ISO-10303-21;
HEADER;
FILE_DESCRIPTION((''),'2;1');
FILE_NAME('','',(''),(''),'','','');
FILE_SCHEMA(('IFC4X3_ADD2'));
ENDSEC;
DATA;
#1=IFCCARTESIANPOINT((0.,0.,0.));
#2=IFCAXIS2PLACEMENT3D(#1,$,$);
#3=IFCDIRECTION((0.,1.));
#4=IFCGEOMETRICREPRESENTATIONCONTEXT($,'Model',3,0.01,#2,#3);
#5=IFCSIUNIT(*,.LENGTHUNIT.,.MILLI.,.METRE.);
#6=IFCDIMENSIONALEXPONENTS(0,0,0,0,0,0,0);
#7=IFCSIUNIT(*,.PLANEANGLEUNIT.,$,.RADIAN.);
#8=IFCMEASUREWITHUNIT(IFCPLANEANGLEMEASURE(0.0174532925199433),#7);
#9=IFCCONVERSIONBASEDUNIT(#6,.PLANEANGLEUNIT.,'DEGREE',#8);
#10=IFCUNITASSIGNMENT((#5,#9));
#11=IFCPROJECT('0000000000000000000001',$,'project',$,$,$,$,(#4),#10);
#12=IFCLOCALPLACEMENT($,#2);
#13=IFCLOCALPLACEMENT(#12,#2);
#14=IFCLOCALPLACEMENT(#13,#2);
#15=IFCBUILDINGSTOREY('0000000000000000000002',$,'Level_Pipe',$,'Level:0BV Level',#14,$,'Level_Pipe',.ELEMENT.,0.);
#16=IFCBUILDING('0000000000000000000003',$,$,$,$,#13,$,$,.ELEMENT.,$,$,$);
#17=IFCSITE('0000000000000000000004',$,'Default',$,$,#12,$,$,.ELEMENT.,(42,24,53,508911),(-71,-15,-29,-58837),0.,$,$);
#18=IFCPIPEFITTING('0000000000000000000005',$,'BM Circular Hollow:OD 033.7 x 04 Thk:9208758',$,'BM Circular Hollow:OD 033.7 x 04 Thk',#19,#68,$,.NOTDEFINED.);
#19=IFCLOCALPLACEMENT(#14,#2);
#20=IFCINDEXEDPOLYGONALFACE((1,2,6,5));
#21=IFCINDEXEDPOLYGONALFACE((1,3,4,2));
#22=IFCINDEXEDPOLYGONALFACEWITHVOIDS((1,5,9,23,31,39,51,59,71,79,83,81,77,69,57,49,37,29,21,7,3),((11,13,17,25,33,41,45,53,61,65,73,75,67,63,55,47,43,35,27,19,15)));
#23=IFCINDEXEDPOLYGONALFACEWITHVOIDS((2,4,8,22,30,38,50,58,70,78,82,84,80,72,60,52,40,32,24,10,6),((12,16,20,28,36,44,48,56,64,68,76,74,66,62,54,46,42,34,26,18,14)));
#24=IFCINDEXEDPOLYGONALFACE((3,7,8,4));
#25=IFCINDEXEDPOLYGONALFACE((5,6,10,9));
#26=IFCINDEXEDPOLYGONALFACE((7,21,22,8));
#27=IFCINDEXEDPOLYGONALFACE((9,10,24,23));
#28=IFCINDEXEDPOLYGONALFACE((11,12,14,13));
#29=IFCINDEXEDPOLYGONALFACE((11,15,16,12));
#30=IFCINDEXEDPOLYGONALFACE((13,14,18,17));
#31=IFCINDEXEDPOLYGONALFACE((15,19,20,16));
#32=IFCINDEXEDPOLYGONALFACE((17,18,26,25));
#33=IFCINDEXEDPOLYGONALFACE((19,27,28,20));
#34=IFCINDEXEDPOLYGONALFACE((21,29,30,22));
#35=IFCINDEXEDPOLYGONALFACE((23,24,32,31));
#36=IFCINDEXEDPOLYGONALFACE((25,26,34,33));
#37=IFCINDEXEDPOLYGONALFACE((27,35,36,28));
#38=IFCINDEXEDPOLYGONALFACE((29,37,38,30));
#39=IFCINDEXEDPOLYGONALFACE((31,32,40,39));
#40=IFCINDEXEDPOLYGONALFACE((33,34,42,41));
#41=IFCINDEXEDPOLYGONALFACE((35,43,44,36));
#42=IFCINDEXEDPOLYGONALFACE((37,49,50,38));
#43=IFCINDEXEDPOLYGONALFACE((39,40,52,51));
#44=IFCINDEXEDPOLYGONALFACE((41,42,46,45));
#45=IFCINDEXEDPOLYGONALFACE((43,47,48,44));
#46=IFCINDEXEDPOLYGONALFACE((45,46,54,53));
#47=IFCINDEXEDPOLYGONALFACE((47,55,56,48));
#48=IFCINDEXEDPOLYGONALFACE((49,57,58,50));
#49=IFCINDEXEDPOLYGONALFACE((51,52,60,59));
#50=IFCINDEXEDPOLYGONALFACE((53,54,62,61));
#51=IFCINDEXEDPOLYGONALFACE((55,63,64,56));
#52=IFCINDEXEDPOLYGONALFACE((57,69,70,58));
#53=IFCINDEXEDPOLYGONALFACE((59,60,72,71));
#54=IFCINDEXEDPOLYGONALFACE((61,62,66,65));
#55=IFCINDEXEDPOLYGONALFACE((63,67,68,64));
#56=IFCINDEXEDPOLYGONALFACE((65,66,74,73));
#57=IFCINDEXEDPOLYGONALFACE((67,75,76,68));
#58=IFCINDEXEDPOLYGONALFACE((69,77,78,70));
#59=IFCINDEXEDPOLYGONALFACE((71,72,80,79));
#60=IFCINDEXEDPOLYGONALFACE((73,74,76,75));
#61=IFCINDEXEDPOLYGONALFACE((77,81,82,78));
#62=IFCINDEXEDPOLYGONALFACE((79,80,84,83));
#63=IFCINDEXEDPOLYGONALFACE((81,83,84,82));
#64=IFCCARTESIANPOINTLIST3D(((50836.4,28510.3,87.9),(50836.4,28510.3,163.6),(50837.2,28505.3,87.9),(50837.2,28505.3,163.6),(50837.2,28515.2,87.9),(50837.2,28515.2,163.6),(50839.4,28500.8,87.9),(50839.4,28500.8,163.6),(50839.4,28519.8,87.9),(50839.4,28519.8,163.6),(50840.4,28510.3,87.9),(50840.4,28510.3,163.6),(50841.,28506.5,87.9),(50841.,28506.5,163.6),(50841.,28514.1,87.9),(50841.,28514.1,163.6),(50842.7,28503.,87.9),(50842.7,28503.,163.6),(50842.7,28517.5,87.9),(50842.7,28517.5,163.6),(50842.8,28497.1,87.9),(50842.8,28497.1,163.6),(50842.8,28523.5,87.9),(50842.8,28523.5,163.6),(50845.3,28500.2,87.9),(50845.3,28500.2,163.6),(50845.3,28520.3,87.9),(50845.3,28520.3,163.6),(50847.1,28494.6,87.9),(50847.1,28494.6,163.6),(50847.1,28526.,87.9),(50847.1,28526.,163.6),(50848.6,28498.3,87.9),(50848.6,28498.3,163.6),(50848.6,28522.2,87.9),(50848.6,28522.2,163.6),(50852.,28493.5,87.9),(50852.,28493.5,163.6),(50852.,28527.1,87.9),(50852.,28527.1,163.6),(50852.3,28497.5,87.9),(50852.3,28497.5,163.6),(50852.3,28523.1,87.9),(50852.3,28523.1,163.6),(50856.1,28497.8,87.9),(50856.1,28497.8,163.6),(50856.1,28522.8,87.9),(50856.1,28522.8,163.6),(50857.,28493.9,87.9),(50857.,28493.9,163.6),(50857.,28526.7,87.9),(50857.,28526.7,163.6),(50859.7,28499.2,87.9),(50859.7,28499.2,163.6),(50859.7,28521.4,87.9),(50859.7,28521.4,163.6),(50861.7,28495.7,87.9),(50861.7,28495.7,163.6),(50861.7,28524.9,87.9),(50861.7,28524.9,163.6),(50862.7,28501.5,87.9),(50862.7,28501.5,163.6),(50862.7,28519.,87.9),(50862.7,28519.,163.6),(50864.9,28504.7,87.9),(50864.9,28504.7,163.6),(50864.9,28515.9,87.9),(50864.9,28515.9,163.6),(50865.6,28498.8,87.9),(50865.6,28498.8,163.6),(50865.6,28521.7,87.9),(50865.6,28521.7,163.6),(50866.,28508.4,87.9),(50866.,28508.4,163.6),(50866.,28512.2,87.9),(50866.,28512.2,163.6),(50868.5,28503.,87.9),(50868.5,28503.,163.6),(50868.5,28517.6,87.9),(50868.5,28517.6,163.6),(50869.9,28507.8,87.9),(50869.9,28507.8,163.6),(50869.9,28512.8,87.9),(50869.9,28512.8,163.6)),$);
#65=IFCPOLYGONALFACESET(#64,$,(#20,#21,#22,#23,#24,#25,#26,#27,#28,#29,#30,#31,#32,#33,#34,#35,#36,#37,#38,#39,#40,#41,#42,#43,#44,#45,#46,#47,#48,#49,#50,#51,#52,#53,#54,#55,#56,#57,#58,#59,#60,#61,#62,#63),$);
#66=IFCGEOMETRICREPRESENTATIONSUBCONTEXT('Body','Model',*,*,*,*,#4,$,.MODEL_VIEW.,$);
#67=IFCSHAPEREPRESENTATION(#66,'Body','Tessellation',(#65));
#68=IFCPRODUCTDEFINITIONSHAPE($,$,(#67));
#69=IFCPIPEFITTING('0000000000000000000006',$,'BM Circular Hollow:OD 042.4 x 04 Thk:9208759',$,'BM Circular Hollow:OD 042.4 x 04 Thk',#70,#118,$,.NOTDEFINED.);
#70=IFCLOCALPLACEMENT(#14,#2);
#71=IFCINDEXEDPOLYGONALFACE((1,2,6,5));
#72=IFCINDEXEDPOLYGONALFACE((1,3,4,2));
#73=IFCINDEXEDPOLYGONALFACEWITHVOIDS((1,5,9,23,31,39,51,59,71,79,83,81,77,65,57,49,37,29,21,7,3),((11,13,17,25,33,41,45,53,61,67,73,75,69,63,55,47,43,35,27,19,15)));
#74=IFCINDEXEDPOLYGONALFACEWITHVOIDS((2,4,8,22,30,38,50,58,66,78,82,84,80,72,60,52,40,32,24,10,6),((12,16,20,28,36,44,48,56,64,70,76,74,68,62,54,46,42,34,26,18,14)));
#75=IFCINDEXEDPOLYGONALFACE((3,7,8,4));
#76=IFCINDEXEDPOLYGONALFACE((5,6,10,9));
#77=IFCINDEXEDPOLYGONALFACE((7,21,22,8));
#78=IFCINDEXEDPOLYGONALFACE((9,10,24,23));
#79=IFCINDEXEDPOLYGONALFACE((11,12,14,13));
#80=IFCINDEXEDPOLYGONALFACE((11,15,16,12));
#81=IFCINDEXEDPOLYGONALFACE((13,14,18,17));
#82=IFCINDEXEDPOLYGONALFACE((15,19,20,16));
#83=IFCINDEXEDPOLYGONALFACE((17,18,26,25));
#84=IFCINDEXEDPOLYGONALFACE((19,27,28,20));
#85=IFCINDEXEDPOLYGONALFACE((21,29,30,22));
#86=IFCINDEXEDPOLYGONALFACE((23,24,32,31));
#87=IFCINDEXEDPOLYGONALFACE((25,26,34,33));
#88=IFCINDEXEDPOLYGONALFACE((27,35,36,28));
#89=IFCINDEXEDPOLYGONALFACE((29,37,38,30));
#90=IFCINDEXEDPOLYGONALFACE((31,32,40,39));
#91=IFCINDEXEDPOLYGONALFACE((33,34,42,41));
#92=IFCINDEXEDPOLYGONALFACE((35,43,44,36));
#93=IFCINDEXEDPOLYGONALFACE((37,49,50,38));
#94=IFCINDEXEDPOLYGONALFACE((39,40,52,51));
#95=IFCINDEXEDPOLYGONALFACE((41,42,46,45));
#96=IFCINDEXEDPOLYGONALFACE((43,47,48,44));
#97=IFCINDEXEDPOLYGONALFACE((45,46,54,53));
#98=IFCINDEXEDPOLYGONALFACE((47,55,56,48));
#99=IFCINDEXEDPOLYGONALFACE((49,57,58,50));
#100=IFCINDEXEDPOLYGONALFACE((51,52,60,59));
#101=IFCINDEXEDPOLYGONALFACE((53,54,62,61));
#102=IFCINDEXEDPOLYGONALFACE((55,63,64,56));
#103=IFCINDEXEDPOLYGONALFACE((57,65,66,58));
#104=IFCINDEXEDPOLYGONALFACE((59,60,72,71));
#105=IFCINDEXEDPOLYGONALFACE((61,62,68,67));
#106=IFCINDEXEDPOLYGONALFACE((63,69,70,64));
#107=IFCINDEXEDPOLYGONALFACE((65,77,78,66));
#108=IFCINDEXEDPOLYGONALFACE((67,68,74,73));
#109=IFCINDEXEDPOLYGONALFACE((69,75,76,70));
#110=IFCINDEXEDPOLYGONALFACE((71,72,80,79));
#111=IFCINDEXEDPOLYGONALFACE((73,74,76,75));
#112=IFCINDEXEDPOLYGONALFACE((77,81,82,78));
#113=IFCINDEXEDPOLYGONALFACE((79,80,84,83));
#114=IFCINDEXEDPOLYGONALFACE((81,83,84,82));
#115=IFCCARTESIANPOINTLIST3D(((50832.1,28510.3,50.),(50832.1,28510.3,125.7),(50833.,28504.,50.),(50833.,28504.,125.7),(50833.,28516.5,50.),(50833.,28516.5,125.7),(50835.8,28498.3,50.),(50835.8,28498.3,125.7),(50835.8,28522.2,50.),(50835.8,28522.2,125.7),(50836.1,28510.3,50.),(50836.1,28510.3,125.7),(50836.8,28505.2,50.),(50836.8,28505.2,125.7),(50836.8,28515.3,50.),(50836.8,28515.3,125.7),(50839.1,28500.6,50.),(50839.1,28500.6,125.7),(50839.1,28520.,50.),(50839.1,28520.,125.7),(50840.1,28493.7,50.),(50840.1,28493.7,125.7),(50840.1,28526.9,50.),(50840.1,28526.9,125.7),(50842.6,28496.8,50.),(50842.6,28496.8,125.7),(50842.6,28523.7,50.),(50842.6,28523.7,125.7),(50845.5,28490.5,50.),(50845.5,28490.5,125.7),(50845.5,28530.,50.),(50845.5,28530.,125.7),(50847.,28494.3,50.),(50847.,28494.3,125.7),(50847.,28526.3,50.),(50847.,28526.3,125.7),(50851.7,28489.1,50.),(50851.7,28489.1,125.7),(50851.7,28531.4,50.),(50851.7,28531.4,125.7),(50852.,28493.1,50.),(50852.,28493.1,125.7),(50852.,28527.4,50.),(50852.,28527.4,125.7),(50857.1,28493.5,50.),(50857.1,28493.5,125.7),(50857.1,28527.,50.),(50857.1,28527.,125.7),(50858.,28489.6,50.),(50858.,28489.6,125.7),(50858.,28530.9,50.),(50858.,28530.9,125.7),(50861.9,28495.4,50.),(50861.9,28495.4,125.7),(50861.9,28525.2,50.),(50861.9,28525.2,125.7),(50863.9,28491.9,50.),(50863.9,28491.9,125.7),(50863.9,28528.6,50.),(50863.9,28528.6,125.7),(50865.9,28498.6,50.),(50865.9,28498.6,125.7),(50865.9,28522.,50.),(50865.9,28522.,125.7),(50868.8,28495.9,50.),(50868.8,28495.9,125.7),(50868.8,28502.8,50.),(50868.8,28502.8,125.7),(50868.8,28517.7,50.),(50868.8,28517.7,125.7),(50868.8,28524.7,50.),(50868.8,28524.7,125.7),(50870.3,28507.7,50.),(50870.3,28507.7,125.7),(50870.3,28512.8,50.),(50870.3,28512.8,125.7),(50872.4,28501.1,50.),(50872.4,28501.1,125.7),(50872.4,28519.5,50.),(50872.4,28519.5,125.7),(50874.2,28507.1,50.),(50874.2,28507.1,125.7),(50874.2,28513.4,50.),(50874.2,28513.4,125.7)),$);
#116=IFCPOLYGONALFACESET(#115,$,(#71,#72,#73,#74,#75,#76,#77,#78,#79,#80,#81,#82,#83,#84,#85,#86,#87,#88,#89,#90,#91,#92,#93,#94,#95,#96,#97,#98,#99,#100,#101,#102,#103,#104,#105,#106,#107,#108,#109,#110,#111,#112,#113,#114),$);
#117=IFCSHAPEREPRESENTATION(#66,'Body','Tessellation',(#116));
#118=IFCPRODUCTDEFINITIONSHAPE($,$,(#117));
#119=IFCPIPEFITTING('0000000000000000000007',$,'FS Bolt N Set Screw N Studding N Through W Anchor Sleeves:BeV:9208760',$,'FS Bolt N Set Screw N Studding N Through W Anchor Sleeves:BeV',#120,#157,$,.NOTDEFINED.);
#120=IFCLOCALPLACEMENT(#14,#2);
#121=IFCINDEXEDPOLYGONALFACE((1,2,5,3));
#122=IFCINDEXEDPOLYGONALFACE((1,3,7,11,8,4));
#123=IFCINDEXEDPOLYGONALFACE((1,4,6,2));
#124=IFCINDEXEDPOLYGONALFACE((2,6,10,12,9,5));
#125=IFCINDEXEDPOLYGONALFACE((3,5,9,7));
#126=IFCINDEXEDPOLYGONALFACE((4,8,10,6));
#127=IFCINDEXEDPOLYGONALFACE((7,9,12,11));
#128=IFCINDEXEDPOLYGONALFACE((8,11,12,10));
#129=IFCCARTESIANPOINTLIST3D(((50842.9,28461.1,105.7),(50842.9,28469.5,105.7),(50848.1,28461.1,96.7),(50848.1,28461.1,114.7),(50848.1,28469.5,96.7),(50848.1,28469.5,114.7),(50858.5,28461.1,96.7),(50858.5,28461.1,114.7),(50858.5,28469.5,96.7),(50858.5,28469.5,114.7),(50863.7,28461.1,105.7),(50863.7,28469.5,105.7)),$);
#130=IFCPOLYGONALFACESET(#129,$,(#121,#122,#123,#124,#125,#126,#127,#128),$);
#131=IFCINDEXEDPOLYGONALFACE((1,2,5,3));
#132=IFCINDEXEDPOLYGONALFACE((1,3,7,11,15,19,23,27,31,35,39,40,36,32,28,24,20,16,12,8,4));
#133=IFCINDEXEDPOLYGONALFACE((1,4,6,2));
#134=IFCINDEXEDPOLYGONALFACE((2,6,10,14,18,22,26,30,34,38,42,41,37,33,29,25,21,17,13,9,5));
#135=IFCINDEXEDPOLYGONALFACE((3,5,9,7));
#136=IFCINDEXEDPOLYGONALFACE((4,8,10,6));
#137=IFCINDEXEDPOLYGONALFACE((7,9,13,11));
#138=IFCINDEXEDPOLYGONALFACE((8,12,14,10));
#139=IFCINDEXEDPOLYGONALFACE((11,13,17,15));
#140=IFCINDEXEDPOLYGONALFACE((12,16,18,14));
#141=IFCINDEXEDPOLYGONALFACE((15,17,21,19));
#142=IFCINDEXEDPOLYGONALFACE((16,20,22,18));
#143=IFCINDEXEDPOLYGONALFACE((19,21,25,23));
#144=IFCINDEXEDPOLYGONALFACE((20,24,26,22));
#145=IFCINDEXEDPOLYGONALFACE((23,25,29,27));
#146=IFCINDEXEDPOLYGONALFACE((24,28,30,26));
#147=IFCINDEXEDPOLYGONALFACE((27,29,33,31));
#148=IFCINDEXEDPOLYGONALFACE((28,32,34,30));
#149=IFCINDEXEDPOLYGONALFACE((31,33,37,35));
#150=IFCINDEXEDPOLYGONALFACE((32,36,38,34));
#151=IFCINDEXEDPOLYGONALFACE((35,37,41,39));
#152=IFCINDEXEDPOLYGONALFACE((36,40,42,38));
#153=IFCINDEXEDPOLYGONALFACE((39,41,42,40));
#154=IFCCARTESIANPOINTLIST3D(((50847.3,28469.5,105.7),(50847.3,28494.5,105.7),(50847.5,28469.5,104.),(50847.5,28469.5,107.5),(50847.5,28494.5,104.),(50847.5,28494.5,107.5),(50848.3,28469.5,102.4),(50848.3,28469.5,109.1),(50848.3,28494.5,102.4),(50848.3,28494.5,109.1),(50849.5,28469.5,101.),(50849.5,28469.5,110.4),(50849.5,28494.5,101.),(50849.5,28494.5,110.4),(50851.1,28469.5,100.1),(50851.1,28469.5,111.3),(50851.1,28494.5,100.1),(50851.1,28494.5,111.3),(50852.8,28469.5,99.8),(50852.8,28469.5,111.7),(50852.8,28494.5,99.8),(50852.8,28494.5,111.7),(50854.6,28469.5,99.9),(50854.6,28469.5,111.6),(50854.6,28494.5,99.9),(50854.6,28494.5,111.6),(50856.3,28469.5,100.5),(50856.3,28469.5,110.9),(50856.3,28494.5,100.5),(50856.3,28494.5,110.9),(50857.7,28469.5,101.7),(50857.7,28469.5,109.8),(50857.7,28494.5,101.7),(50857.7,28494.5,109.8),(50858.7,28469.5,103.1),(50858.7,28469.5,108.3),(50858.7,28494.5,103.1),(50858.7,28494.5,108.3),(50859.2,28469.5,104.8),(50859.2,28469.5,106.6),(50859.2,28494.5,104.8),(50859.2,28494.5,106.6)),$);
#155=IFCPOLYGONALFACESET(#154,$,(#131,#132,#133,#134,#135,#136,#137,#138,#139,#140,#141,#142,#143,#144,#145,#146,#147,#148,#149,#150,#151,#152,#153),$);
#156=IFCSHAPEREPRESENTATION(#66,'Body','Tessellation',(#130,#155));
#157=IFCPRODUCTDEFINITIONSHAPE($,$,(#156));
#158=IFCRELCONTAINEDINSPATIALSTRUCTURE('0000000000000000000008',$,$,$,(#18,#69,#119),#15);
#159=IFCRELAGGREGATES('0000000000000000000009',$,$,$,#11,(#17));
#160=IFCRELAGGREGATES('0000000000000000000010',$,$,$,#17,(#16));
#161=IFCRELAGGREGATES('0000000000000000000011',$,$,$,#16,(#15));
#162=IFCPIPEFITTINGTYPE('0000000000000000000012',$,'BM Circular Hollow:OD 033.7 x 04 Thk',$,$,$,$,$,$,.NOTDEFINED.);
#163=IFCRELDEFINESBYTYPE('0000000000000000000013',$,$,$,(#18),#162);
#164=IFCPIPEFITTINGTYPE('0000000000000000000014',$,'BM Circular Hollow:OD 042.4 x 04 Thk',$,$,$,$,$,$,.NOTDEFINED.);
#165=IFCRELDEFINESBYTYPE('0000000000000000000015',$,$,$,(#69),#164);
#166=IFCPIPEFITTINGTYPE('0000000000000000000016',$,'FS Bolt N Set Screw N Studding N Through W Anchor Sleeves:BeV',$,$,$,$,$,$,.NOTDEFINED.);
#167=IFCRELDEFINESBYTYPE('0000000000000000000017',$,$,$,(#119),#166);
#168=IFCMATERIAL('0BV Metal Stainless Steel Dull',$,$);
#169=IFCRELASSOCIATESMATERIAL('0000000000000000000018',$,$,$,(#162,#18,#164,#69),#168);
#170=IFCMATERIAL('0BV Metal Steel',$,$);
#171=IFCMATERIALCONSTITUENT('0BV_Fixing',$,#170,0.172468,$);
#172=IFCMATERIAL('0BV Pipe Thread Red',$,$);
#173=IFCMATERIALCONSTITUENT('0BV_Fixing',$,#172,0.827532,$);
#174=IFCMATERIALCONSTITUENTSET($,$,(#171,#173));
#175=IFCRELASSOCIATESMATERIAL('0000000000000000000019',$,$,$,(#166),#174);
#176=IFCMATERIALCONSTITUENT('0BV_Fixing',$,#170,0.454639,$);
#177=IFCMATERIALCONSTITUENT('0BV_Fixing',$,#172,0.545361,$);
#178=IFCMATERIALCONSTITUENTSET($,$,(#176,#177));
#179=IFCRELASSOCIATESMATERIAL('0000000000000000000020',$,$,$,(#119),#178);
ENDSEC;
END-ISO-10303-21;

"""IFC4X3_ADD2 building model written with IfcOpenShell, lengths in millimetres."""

from ifc_helpers import new_model, entity, si_unit, converted_unit, direction, frame, frame_2d, origin, place, context, subcontext, project, spatial, polyline, circle, hollow_circle, outline, extrude, source, transform, mapped, material, constituent, constituent_set, type_object, type_shapes, element, save


model = new_model("IFC4X3_ADD2")

# Units and contexts
model_context = context("Model", 3, precision=0.01, world=origin(), true_north=direction((0.0, 1.0)))
body_context = subcontext(model_context, "Body", "Model", "MODEL_VIEW")
ifc_project = project(units=[si_unit("LENGTHUNIT", "METRE", prefix="MILLI"), converted_unit("PLANEANGLEUNIT", "DEGREE", entity("IfcPlaneAngleMeasure", 0.0174532925199433), si_unit("PLANEANGLEUNIT", "RADIAN"), dimensions=[0, 0, 0, 0, 0, 0, 0])], contexts=[model_context])

# Site, building, storey
site_placement = place(None, origin())
site = spatial("IfcSite", under=ifc_project, at=site_placement, Name="Default", CompositionType="ELEMENT", RefLatitude=(42, 24, 53, 508911), RefLongitude=(-71, -15, -29, -58837), RefElevation=0.0)
building_placement = place(site_placement, origin())
building = spatial("IfcBuilding", under=site, at=building_placement, CompositionType="ELEMENT")
storey_placement = place(building_placement, origin())
storey = spatial("IfcBuildingStorey", under=building, at=storey_placement, Name="Level_Pipe", ObjectType="Level:0BV Level", LongName="Level_Pipe", CompositionType="ELEMENT", Elevation=0.0)

# Pipe fittings
ifc_material_1 = material(Name="0BV Metal Stainless Steel Dull")
ifc_material_2 = material(Name="0BV Metal Steel")
pipe_fitting_type_1 = type_object("IfcPipeFittingType", Name="BM Circular Hollow:OD 033.7 x 04 Thk", PredefinedType="NOTDEFINED", material=ifc_material_1)
shared_shape_1 = source(origin(), body_context, "Body", "SweptSolid", [
    extrude(hollow_circle(Radius=16.9, WallThickness=4.0, at=frame_2d((0.0, 0.0), x_axis=(1.0, 0.0))), frame((-37.9, 0.0, 0.0), z_axis=(1.0, 0.0, 0.0), x_axis=(0.0, 1.0, 0.0)), (0.0, 0.0, 1.0), 75.7),
])
type_shapes(pipe_fitting_type_1, [shared_shape_1])
pipe_fitting_1_placement = place(storey_placement, frame((50853.3, 28510.3, 125.7), z_axis=(0.0, -1.0, 0.0), x_axis=(0.0, 0.0, 1.0)))
element("IfcPipeFitting", 1, at=pipe_fitting_1_placement, inside=storey, type_object=pipe_fitting_type_1, material=ifc_material_1, Name="BM Circular Hollow:OD 033.7 x 04 Thk:9208758", ObjectType="BM Circular Hollow:OD 033.7 x 04 Thk", PredefinedType="NOTDEFINED", context=body_context, shape_type="MappedRepresentation", body=[
    mapped(shared_shape_1, transform((0.0, 0.0, 0.0), scale=1.0)),
])
pipe_fitting_type_2 = type_object("IfcPipeFittingType", Name="BM Circular Hollow:OD 042.4 x 04 Thk", PredefinedType="NOTDEFINED", material=ifc_material_1)
shared_shape_2 = source(origin(), body_context, "Body", "SweptSolid", [
    extrude(hollow_circle(Radius=21.2, WallThickness=4.0, at=frame_2d((0.0, 0.0), x_axis=(1.0, 0.0))), frame((-37.9, 0.0, 0.0), z_axis=(1.0, 0.0, 0.0), x_axis=(0.0, 1.0, 0.0)), (0.0, 0.0, 1.0), 75.7),
])
type_shapes(pipe_fitting_type_2, [shared_shape_2])
pipe_fitting_2_placement = place(storey_placement, frame((50853.3, 28510.3, 87.9), z_axis=(0.0, -1.0, 0.0), x_axis=(0.0, 0.0, 1.0)))
element("IfcPipeFitting", 2, at=pipe_fitting_2_placement, inside=storey, type_object=pipe_fitting_type_2, material=ifc_material_1, Name="BM Circular Hollow:OD 042.4 x 04 Thk:9208759", ObjectType="BM Circular Hollow:OD 042.4 x 04 Thk", PredefinedType="NOTDEFINED", context=body_context, shape_type="MappedRepresentation", body=[
    mapped(shared_shape_2, transform((0.0, 0.0, 0.0), scale=1.0)),
])
ifc_constituent_1 = constituent(ifc_material_2, Name="0BV_Fixing", fraction=0.454639)
ifc_material_3 = material(Name="0BV Pipe Thread Red")
ifc_constituent_2 = constituent(ifc_material_3, Name="0BV_Fixing", fraction=0.545361)
ifc_constituent_set_1 = constituent_set(constituents=[ifc_constituent_1, ifc_constituent_2])
ifc_constituent_3 = constituent(ifc_material_2, Name="0BV_Fixing", fraction=0.172468)
ifc_constituent_4 = constituent(ifc_material_3, Name="0BV_Fixing", fraction=0.827532)
ifc_constituent_set_2 = constituent_set(constituents=[ifc_constituent_3, ifc_constituent_4])
pipe_fitting_type_3 = type_object("IfcPipeFittingType", Name="FS Bolt N Set Screw N Studding N Through W Anchor Sleeves:BeV", PredefinedType="NOTDEFINED", material=ifc_constituent_set_2)
shared_shape_3 = source(origin(), body_context, "Body", "SweptSolid", [
    extrude(outline(polyline([(-5.2, -9.0), (5.2, -9.0), (10.4, 0.0), (5.2, 9.0), (-5.2, 9.0), (-10.4, 0.0), (-5.2, -9.0)])), frame((-8.4, 0.0, 0.0), z_axis=(1.0, 0.0, 0.0), x_axis=(0.0, -0.5, -0.866025)), (0.0, 0.0, 1.0), 8.4),
    extrude(circle(Radius=6.0, at=frame_2d((0.0, 0.0), x_axis=(1.0, 0.0))), frame((0.0, 0.0, 0.0), z_axis=(1.0, 0.0, 0.0), x_axis=(0.0, 1.0, 0.0)), (0.0, 0.0, 1.0), 25.0),
])
type_shapes(pipe_fitting_type_3, [shared_shape_3])
pipe_fitting_3_placement = place(storey_placement, frame((50853.3, 28469.5, 105.7), z_axis=(0.0, 0.0, 1.0), x_axis=(0.0, 1.0, 0.0)))
element("IfcPipeFitting", 3, at=pipe_fitting_3_placement, inside=storey, type_object=pipe_fitting_type_3, material=ifc_constituent_set_1, Name="FS Bolt N Set Screw N Studding N Through W Anchor Sleeves:BeV:9208760", ObjectType="FS Bolt N Set Screw N Studding N Through W Anchor Sleeves:BeV", PredefinedType="NOTDEFINED", context=body_context, shape_type="MappedRepresentation", body=[
    mapped(shared_shape_3, transform((0.0, 0.0, 0.0), scale=1.0)),
])

save(model, "model.ifc")
